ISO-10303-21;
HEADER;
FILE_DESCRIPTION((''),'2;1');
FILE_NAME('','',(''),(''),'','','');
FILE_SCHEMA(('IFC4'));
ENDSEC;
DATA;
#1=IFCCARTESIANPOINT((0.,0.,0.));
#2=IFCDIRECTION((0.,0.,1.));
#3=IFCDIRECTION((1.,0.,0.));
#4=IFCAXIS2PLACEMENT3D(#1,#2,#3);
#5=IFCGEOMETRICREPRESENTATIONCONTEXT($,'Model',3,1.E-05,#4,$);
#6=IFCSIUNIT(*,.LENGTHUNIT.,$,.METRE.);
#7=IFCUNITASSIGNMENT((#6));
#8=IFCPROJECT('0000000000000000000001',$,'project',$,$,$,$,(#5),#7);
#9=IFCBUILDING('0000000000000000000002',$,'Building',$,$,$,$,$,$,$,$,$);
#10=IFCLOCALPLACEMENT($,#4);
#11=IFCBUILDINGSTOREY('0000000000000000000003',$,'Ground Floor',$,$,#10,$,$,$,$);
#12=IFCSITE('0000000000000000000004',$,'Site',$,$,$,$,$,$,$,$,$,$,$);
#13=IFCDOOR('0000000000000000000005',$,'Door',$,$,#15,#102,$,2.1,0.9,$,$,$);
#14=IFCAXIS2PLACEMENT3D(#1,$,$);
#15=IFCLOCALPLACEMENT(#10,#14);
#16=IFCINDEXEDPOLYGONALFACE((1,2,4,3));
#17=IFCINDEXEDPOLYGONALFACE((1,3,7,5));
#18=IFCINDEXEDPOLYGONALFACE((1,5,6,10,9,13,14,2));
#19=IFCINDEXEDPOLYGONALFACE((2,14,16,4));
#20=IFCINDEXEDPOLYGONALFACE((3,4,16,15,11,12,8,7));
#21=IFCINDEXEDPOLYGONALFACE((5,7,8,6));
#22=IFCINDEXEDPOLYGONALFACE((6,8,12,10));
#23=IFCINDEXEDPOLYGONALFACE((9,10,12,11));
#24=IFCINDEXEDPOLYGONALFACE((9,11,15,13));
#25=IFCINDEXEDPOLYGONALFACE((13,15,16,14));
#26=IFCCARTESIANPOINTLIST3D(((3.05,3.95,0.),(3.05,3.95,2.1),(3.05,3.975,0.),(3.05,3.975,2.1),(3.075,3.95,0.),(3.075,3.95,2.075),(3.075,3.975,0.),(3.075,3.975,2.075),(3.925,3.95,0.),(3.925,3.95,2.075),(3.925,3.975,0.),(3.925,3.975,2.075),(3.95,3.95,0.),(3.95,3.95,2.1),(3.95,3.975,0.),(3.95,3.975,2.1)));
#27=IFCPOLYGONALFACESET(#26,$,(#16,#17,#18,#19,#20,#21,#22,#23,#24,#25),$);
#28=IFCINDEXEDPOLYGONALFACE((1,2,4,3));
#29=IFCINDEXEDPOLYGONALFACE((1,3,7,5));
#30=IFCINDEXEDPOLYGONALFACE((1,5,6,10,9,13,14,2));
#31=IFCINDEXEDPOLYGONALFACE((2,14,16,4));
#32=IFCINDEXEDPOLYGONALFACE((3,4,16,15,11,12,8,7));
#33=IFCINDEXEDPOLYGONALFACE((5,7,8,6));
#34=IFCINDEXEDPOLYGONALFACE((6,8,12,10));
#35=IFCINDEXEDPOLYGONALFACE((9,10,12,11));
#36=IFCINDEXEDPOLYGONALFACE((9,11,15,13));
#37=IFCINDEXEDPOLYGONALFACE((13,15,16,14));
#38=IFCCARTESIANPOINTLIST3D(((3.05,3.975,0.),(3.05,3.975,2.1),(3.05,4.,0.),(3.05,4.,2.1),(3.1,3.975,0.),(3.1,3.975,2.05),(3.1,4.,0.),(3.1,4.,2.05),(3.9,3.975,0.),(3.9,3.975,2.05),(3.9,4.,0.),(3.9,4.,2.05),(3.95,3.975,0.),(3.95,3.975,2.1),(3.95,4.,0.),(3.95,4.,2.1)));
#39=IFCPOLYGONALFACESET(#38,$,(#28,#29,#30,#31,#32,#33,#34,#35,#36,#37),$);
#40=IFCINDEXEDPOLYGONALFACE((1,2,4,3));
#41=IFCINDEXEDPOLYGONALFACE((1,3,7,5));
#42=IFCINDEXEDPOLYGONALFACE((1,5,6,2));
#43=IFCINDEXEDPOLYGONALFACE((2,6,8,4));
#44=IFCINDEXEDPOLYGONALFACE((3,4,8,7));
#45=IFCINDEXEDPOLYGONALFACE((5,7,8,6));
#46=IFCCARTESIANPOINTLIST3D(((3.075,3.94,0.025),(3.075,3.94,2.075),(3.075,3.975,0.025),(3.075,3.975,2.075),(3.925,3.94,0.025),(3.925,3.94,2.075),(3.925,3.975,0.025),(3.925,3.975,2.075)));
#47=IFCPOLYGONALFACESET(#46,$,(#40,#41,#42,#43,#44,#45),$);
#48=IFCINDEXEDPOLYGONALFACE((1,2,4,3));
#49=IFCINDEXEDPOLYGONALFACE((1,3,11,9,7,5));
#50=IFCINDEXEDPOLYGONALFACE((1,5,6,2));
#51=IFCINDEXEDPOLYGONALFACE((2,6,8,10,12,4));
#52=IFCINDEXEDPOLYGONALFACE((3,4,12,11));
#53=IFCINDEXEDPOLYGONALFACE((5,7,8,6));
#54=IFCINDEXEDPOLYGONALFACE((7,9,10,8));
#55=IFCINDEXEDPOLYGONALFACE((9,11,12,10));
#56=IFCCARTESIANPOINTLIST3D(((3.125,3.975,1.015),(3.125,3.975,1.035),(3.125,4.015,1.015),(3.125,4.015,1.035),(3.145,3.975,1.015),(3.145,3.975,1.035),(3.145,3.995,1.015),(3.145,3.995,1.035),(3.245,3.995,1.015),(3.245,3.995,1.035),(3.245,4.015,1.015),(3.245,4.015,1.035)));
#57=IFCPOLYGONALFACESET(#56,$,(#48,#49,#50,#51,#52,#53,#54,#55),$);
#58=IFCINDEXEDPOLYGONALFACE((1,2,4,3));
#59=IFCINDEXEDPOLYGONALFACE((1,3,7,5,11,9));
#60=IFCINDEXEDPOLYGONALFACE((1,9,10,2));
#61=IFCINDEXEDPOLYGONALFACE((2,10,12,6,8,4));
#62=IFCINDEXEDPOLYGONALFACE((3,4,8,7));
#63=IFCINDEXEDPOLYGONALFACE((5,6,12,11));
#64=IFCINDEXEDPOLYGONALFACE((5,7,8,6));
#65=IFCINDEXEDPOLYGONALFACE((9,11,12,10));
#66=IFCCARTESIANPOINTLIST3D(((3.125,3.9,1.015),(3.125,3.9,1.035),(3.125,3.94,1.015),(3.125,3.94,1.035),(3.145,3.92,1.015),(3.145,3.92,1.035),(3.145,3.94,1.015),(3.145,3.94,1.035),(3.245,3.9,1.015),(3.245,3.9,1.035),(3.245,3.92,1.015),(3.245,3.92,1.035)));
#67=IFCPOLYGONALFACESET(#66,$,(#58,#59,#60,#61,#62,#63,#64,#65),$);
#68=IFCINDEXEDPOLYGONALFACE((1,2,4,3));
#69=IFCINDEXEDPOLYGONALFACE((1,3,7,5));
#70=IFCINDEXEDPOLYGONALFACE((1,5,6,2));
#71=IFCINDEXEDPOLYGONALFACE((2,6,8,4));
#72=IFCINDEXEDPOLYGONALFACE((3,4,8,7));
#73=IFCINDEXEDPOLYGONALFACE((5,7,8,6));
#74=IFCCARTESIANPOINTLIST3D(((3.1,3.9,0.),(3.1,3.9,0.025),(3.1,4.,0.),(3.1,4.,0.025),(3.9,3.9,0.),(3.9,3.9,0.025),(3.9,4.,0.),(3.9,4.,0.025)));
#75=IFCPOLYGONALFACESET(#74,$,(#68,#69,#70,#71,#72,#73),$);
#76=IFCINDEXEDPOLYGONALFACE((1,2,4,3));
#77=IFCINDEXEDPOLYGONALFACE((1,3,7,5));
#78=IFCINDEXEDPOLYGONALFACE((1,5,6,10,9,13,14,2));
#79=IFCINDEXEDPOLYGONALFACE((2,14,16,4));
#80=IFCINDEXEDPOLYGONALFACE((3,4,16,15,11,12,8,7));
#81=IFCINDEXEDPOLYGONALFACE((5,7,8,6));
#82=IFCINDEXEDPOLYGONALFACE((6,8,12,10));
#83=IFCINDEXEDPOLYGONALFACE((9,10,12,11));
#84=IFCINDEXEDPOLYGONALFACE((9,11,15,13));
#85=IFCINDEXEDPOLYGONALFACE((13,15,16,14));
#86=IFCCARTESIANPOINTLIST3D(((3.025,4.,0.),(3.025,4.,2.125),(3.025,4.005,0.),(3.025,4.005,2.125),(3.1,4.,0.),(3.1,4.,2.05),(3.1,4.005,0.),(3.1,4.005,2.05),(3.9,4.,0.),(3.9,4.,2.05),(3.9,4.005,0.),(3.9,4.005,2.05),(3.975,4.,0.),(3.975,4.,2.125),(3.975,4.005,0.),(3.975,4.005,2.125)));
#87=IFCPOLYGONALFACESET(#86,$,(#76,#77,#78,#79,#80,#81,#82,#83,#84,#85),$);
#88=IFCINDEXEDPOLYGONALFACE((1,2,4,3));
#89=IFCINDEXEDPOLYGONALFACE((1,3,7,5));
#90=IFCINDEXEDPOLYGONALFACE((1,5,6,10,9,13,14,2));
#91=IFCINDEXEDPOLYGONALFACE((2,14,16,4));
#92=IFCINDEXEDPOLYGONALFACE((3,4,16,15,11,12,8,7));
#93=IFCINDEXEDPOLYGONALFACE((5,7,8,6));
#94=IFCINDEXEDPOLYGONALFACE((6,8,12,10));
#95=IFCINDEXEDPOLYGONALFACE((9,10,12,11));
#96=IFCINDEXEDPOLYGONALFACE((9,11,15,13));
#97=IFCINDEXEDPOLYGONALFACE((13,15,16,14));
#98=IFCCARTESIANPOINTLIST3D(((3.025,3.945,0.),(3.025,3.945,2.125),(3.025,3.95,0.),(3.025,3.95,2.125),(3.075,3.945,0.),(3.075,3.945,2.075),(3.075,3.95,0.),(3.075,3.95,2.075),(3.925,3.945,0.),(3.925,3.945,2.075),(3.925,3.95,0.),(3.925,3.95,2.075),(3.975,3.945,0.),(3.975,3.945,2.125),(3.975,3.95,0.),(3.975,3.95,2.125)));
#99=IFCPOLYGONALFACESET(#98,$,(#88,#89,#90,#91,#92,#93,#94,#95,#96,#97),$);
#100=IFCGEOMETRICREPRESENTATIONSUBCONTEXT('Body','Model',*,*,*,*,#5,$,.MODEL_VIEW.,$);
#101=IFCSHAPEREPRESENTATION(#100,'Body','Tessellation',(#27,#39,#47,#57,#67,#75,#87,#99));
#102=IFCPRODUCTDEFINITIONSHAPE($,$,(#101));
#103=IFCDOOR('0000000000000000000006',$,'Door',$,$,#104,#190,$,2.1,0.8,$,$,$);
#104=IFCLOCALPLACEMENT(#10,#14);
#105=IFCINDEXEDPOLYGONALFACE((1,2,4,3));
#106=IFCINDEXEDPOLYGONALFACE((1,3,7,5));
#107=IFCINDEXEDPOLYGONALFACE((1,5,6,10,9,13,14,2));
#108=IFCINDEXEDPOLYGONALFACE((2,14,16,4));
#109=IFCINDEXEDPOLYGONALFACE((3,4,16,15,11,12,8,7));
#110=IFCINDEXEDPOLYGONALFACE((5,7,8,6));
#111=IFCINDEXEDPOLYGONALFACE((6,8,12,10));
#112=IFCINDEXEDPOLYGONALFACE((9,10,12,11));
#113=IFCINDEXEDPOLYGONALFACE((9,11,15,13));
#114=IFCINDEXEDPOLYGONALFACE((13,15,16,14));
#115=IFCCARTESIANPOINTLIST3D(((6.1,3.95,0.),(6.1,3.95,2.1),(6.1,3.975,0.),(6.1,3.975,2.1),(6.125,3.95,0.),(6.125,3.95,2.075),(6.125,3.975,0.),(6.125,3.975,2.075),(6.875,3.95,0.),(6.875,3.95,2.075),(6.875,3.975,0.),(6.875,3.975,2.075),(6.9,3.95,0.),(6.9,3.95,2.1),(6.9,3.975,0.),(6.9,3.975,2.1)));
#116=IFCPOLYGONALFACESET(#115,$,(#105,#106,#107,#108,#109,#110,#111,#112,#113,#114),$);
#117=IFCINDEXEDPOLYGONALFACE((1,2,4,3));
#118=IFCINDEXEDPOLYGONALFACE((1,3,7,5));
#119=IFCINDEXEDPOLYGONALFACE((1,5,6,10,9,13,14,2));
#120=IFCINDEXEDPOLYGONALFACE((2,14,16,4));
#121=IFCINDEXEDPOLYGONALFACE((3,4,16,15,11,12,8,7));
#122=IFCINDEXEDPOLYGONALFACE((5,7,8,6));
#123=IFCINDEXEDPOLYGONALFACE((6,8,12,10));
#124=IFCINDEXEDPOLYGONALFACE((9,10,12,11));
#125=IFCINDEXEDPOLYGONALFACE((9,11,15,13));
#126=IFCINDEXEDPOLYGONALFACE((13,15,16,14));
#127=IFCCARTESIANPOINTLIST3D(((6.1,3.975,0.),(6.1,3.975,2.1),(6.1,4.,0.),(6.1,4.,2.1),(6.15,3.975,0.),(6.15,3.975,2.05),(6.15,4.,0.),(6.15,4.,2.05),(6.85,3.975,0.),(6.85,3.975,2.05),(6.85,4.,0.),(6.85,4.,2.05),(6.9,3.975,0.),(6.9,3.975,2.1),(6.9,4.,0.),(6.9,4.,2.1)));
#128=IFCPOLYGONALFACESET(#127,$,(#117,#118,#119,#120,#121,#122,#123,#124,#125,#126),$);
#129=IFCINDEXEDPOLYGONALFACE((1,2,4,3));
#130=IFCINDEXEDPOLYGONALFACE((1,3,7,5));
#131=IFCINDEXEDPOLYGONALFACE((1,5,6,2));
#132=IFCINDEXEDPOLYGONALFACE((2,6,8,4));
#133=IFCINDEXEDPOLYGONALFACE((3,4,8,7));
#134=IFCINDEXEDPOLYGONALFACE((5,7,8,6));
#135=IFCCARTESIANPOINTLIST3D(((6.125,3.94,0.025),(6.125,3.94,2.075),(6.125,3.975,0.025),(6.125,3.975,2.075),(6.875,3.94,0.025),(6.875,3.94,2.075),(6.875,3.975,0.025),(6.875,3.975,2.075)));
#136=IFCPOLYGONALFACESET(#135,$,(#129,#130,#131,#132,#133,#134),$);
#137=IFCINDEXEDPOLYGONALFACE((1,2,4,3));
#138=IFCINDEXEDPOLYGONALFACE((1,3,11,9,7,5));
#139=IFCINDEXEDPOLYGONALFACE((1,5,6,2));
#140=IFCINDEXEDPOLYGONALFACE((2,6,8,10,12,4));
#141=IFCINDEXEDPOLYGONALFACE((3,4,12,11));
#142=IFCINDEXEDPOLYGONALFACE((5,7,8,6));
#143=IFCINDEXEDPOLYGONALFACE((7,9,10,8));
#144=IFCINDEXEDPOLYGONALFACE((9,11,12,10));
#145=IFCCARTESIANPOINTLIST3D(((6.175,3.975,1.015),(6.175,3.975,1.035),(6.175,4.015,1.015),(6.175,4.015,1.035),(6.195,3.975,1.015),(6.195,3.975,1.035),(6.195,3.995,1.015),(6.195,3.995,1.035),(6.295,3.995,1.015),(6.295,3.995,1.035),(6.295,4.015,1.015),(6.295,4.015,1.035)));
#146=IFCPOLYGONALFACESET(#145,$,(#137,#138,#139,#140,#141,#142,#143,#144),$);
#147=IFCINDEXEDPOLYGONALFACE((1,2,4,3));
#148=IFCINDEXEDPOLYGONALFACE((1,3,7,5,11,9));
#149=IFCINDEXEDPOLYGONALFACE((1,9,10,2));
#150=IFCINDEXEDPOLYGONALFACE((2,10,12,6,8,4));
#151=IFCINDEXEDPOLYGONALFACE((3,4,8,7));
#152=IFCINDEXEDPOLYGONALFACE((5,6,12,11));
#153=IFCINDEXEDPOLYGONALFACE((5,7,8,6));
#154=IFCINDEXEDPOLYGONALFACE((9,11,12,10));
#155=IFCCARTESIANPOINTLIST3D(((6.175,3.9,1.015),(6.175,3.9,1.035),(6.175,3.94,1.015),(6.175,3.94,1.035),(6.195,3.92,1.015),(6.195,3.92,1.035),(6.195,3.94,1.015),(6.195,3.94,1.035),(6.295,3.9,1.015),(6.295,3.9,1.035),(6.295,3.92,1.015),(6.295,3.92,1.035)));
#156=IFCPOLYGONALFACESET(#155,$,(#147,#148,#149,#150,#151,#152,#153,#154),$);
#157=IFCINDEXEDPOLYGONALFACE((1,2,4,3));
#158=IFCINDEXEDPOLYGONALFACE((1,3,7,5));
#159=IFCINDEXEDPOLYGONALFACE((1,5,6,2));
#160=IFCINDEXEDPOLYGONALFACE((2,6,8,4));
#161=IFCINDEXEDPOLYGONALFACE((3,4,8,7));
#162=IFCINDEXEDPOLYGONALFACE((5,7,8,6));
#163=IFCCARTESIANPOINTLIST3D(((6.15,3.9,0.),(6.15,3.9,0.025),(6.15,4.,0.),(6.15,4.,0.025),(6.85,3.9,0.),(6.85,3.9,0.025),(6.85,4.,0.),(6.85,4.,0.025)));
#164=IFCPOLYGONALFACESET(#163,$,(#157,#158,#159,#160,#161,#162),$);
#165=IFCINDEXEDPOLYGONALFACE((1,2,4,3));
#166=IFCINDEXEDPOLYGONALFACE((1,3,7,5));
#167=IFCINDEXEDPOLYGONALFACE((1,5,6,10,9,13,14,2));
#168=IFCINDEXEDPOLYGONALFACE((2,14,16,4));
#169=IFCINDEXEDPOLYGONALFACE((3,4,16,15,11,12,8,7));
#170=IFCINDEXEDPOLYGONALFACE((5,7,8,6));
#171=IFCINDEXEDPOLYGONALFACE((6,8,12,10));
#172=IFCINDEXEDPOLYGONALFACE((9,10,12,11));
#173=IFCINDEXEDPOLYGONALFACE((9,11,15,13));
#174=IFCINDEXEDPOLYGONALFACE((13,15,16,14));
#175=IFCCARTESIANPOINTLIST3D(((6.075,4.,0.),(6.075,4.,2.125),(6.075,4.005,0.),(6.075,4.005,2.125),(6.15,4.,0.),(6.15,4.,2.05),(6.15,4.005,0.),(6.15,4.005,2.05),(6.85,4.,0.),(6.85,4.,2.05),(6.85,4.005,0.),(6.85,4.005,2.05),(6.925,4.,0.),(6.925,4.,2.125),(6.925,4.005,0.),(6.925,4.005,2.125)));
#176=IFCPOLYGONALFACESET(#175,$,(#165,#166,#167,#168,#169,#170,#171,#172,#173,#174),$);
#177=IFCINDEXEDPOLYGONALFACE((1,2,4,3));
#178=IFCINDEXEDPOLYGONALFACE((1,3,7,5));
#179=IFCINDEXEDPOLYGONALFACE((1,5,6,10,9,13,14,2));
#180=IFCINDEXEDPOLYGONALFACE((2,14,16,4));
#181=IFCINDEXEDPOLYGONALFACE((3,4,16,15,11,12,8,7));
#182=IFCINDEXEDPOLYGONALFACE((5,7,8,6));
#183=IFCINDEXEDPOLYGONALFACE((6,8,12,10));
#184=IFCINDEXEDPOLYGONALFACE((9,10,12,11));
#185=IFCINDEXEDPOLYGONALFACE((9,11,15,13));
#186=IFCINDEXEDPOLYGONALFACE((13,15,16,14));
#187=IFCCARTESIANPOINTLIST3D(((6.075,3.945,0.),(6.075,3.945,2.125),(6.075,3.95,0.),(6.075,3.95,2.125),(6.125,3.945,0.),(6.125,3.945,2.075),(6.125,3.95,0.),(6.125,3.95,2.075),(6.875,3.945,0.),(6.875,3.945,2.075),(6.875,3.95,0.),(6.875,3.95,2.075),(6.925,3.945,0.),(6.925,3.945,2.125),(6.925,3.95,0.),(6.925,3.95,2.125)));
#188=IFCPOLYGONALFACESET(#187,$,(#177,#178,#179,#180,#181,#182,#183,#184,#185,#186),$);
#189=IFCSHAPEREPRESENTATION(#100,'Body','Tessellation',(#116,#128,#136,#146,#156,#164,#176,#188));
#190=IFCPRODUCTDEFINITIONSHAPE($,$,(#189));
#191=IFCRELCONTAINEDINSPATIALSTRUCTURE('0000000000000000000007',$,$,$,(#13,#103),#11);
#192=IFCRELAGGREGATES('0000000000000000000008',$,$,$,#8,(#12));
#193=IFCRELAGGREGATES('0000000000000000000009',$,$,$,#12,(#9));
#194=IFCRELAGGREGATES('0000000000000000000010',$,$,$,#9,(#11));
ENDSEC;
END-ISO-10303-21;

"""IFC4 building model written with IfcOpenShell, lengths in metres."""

from ifc_helpers import new_model, si_unit, frame, origin_with_axes, place, context, subcontext, project, spatial, line, indexed_curve, outline, extrude, element, save


model = new_model("IFC4")

# Units and contexts
model_context = context("Model", 3, precision=1e-05, world=origin_with_axes())
body_context = subcontext(model_context, "Body", "Model", "MODEL_VIEW")
ifc_project = project(units=[si_unit("LENGTHUNIT", "METRE")], contexts=[model_context])

# Site, building, storey
site = spatial("IfcSite", under=ifc_project, Name="Site")
building = spatial("IfcBuilding", under=site, Name="Building")
storey_placement = place(None, origin_with_axes())
storey = spatial("IfcBuildingStorey", under=building, at=storey_placement, Name="Ground Floor")

# Doors
door_1_placement = place(storey_placement, frame((3.95, 4.0, 0.0), z_axis=(0.0, 0.0, 1.0), x_axis=(-1.0, 0.0, 0.0)))
element("IfcDoor", 1, at=door_1_placement, inside=storey, Name="Door", OverallHeight=2.1, OverallWidth=0.9, context=body_context, shape_type="SweptSolid", body=[
    extrude(outline(indexed_curve([(0.0, 0.0), (0.0, 2.1), (0.9, 2.1), (0.9, 0.0), (0.875, 0.0), (0.875, 2.075), (0.025, 2.075), (0.025, 0.0)], segments=[line(1, 2, 3, 4, 5, 6, 7, 8, 1)])), frame((0.0, 0.025, 0.0), z_axis=(0.0, -1.0, 0.0), x_axis=(1.0, 0.0, 0.0)), (0.0, 0.0, -1.0), 0.025),
    extrude(outline(indexed_curve([(0.0, 0.0), (0.0, 2.1), (0.9, 2.1), (0.9, 0.0), (0.85, 0.0), (0.85, 2.05), (0.05, 2.05), (0.05, 0.0)], segments=[line(1, 2, 3, 4, 5, 6, 7, 8, 1)])), frame((0.0, 0.0, 0.0), z_axis=(0.0, -1.0, 0.0), x_axis=(1.0, 0.0, 0.0)), (0.0, 0.0, -1.0), 0.025),
    extrude(outline(indexed_curve([(0.0, 0.0), (0.85, 0.0), (0.85, 0.035), (0.0, 0.035)], segments=[line(1, 2, 3, 4, 1)])), frame((0.025, 0.025, 0.025), z_axis=(0.0, 0.0, 1.0), x_axis=(1.0, 0.0, 0.0)), (0.0, 0.0, 1.0), 2.05),
    extrude(outline(indexed_curve([(0.0, 0.0), (0.0, -0.04), (-0.12, -0.04), (-0.12, -0.02), (-0.02, -0.02), (-0.02, 0.0)], segments=[line(1, 2, 3, 4, 5, 6, 1)])), frame((0.825, 0.025, 1.015), z_axis=(0.0, 0.0, 1.0), x_axis=(1.0, 0.0, 0.0)), (0.0, 0.0, 1.0), 0.02),
    extrude(outline(indexed_curve([(0.0, 0.0), (0.0, 0.04), (-0.12, 0.04), (-0.12, 0.02), (-0.02, 0.02), (-0.02, 0.0)], segments=[line(1, 2, 3, 4, 5, 6, 1)])), frame((0.825, 0.06, 1.015), z_axis=(0.0, 0.0, 1.0), x_axis=(1.0, 0.0, 0.0)), (0.0, 0.0, 1.0), 0.02),
    extrude(outline(indexed_curve([(0.0, 0.0), (0.8, 0.0), (0.8, 0.1), (0.0, 0.1)], segments=[line(1, 2, 3, 4, 1)])), frame((0.05, 0.0, 0.0), z_axis=(0.0, 0.0, 1.0), x_axis=(1.0, 0.0, 0.0)), (0.0, 0.0, 1.0), 0.025),
    extrude(outline(indexed_curve([(0.0, 0.0), (0.0, 2.125), (0.95, 2.125), (0.95, 0.0), (0.875, 0.0), (0.875, 2.05), (0.075, 2.05), (0.075, 0.0)], segments=[line(1, 2, 3, 4, 5, 6, 7, 8, 1)])), frame((-0.025, -0.005, 0.0), z_axis=(0.0, -1.0, 0.0), x_axis=(1.0, 0.0, 0.0)), (0.0, 0.0, -1.0), 0.005),
    extrude(outline(indexed_curve([(0.0, 0.0), (0.0, 2.125), (0.95, 2.125), (0.95, 0.0), (0.9, 0.0), (0.9, 2.075), (0.05, 2.075), (0.05, 0.0)], segments=[line(1, 2, 3, 4, 5, 6, 7, 8, 1)])), frame((-0.025, 0.05, 0.0), z_axis=(0.0, -1.0, 0.0), x_axis=(1.0, 0.0, 0.0)), (0.0, 0.0, -1.0), 0.005),
])
door_2_placement = place(storey_placement, frame((6.9, 4.0, 0.0), z_axis=(0.0, 0.0, 1.0), x_axis=(-1.0, 0.0, 0.0)))
element("IfcDoor", 2, at=door_2_placement, inside=storey, Name="Door", OverallHeight=2.1, OverallWidth=0.8, context=body_context, shape_type="SweptSolid", body=[
    extrude(outline(indexed_curve([(0.0, 0.0), (0.0, 2.1), (0.8, 2.1), (0.8, 0.0), (0.775, 0.0), (0.775, 2.075), (0.025, 2.075), (0.025, 0.0)], segments=[line(1, 2, 3, 4, 5, 6, 7, 8, 1)])), frame((0.0, 0.025, 0.0), z_axis=(0.0, -1.0, 0.0), x_axis=(1.0, 0.0, 0.0)), (0.0, 0.0, -1.0), 0.025),
    extrude(outline(indexed_curve([(0.0, 0.0), (0.0, 2.1), (0.8, 2.1), (0.8, 0.0), (0.75, 0.0), (0.75, 2.05), (0.05, 2.05), (0.05, 0.0)], segments=[line(1, 2, 3, 4, 5, 6, 7, 8, 1)])), frame((0.0, 0.0, 0.0), z_axis=(0.0, -1.0, 0.0), x_axis=(1.0, 0.0, 0.0)), (0.0, 0.0, -1.0), 0.025),
    extrude(outline(indexed_curve([(0.0, 0.0), (0.75, 0.0), (0.75, 0.035), (0.0, 0.035)], segments=[line(1, 2, 3, 4, 1)])), frame((0.025, 0.025, 0.025), z_axis=(0.0, 0.0, 1.0), x_axis=(1.0, 0.0, 0.0)), (0.0, 0.0, 1.0), 2.05),
    extrude(outline(indexed_curve([(0.0, 0.0), (0.0, -0.04), (-0.12, -0.04), (-0.12, -0.02), (-0.02, -0.02), (-0.02, 0.0)], segments=[line(1, 2, 3, 4, 5, 6, 1)])), frame((0.725, 0.025, 1.015), z_axis=(0.0, 0.0, 1.0), x_axis=(1.0, 0.0, 0.0)), (0.0, 0.0, 1.0), 0.02),
    extrude(outline(indexed_curve([(0.0, 0.0), (0.0, 0.04), (-0.12, 0.04), (-0.12, 0.02), (-0.02, 0.02), (-0.02, 0.0)], segments=[line(1, 2, 3, 4, 5, 6, 1)])), frame((0.725, 0.06, 1.015), z_axis=(0.0, 0.0, 1.0), x_axis=(1.0, 0.0, 0.0)), (0.0, 0.0, 1.0), 0.02),
    extrude(outline(indexed_curve([(0.0, 0.0), (0.7, 0.0), (0.7, 0.1), (0.0, 0.1)], segments=[line(1, 2, 3, 4, 1)])), frame((0.05, 0.0, 0.0), z_axis=(0.0, 0.0, 1.0), x_axis=(1.0, 0.0, 0.0)), (0.0, 0.0, 1.0), 0.025),
    extrude(outline(indexed_curve([(0.0, 0.0), (0.0, 2.125), (0.85, 2.125), (0.85, 0.0), (0.775, 0.0), (0.775, 2.05), (0.075, 2.05), (0.075, 0.0)], segments=[line(1, 2, 3, 4, 5, 6, 7, 8, 1)])), frame((-0.025, -0.005, 0.0), z_axis=(0.0, -1.0, 0.0), x_axis=(1.0, 0.0, 0.0)), (0.0, 0.0, -1.0), 0.005),
    extrude(outline(indexed_curve([(0.0, 0.0), (0.0, 2.125), (0.85, 2.125), (0.85, 0.0), (0.8, 0.0), (0.8, 2.075), (0.05, 2.075), (0.05, 0.0)], segments=[line(1, 2, 3, 4, 5, 6, 7, 8, 1)])), frame((-0.025, 0.05, 0.0), z_axis=(0.0, -1.0, 0.0), x_axis=(1.0, 0.0, 0.0)), (0.0, 0.0, -1.0), 0.005),
])

save(model, "model.ifc")
